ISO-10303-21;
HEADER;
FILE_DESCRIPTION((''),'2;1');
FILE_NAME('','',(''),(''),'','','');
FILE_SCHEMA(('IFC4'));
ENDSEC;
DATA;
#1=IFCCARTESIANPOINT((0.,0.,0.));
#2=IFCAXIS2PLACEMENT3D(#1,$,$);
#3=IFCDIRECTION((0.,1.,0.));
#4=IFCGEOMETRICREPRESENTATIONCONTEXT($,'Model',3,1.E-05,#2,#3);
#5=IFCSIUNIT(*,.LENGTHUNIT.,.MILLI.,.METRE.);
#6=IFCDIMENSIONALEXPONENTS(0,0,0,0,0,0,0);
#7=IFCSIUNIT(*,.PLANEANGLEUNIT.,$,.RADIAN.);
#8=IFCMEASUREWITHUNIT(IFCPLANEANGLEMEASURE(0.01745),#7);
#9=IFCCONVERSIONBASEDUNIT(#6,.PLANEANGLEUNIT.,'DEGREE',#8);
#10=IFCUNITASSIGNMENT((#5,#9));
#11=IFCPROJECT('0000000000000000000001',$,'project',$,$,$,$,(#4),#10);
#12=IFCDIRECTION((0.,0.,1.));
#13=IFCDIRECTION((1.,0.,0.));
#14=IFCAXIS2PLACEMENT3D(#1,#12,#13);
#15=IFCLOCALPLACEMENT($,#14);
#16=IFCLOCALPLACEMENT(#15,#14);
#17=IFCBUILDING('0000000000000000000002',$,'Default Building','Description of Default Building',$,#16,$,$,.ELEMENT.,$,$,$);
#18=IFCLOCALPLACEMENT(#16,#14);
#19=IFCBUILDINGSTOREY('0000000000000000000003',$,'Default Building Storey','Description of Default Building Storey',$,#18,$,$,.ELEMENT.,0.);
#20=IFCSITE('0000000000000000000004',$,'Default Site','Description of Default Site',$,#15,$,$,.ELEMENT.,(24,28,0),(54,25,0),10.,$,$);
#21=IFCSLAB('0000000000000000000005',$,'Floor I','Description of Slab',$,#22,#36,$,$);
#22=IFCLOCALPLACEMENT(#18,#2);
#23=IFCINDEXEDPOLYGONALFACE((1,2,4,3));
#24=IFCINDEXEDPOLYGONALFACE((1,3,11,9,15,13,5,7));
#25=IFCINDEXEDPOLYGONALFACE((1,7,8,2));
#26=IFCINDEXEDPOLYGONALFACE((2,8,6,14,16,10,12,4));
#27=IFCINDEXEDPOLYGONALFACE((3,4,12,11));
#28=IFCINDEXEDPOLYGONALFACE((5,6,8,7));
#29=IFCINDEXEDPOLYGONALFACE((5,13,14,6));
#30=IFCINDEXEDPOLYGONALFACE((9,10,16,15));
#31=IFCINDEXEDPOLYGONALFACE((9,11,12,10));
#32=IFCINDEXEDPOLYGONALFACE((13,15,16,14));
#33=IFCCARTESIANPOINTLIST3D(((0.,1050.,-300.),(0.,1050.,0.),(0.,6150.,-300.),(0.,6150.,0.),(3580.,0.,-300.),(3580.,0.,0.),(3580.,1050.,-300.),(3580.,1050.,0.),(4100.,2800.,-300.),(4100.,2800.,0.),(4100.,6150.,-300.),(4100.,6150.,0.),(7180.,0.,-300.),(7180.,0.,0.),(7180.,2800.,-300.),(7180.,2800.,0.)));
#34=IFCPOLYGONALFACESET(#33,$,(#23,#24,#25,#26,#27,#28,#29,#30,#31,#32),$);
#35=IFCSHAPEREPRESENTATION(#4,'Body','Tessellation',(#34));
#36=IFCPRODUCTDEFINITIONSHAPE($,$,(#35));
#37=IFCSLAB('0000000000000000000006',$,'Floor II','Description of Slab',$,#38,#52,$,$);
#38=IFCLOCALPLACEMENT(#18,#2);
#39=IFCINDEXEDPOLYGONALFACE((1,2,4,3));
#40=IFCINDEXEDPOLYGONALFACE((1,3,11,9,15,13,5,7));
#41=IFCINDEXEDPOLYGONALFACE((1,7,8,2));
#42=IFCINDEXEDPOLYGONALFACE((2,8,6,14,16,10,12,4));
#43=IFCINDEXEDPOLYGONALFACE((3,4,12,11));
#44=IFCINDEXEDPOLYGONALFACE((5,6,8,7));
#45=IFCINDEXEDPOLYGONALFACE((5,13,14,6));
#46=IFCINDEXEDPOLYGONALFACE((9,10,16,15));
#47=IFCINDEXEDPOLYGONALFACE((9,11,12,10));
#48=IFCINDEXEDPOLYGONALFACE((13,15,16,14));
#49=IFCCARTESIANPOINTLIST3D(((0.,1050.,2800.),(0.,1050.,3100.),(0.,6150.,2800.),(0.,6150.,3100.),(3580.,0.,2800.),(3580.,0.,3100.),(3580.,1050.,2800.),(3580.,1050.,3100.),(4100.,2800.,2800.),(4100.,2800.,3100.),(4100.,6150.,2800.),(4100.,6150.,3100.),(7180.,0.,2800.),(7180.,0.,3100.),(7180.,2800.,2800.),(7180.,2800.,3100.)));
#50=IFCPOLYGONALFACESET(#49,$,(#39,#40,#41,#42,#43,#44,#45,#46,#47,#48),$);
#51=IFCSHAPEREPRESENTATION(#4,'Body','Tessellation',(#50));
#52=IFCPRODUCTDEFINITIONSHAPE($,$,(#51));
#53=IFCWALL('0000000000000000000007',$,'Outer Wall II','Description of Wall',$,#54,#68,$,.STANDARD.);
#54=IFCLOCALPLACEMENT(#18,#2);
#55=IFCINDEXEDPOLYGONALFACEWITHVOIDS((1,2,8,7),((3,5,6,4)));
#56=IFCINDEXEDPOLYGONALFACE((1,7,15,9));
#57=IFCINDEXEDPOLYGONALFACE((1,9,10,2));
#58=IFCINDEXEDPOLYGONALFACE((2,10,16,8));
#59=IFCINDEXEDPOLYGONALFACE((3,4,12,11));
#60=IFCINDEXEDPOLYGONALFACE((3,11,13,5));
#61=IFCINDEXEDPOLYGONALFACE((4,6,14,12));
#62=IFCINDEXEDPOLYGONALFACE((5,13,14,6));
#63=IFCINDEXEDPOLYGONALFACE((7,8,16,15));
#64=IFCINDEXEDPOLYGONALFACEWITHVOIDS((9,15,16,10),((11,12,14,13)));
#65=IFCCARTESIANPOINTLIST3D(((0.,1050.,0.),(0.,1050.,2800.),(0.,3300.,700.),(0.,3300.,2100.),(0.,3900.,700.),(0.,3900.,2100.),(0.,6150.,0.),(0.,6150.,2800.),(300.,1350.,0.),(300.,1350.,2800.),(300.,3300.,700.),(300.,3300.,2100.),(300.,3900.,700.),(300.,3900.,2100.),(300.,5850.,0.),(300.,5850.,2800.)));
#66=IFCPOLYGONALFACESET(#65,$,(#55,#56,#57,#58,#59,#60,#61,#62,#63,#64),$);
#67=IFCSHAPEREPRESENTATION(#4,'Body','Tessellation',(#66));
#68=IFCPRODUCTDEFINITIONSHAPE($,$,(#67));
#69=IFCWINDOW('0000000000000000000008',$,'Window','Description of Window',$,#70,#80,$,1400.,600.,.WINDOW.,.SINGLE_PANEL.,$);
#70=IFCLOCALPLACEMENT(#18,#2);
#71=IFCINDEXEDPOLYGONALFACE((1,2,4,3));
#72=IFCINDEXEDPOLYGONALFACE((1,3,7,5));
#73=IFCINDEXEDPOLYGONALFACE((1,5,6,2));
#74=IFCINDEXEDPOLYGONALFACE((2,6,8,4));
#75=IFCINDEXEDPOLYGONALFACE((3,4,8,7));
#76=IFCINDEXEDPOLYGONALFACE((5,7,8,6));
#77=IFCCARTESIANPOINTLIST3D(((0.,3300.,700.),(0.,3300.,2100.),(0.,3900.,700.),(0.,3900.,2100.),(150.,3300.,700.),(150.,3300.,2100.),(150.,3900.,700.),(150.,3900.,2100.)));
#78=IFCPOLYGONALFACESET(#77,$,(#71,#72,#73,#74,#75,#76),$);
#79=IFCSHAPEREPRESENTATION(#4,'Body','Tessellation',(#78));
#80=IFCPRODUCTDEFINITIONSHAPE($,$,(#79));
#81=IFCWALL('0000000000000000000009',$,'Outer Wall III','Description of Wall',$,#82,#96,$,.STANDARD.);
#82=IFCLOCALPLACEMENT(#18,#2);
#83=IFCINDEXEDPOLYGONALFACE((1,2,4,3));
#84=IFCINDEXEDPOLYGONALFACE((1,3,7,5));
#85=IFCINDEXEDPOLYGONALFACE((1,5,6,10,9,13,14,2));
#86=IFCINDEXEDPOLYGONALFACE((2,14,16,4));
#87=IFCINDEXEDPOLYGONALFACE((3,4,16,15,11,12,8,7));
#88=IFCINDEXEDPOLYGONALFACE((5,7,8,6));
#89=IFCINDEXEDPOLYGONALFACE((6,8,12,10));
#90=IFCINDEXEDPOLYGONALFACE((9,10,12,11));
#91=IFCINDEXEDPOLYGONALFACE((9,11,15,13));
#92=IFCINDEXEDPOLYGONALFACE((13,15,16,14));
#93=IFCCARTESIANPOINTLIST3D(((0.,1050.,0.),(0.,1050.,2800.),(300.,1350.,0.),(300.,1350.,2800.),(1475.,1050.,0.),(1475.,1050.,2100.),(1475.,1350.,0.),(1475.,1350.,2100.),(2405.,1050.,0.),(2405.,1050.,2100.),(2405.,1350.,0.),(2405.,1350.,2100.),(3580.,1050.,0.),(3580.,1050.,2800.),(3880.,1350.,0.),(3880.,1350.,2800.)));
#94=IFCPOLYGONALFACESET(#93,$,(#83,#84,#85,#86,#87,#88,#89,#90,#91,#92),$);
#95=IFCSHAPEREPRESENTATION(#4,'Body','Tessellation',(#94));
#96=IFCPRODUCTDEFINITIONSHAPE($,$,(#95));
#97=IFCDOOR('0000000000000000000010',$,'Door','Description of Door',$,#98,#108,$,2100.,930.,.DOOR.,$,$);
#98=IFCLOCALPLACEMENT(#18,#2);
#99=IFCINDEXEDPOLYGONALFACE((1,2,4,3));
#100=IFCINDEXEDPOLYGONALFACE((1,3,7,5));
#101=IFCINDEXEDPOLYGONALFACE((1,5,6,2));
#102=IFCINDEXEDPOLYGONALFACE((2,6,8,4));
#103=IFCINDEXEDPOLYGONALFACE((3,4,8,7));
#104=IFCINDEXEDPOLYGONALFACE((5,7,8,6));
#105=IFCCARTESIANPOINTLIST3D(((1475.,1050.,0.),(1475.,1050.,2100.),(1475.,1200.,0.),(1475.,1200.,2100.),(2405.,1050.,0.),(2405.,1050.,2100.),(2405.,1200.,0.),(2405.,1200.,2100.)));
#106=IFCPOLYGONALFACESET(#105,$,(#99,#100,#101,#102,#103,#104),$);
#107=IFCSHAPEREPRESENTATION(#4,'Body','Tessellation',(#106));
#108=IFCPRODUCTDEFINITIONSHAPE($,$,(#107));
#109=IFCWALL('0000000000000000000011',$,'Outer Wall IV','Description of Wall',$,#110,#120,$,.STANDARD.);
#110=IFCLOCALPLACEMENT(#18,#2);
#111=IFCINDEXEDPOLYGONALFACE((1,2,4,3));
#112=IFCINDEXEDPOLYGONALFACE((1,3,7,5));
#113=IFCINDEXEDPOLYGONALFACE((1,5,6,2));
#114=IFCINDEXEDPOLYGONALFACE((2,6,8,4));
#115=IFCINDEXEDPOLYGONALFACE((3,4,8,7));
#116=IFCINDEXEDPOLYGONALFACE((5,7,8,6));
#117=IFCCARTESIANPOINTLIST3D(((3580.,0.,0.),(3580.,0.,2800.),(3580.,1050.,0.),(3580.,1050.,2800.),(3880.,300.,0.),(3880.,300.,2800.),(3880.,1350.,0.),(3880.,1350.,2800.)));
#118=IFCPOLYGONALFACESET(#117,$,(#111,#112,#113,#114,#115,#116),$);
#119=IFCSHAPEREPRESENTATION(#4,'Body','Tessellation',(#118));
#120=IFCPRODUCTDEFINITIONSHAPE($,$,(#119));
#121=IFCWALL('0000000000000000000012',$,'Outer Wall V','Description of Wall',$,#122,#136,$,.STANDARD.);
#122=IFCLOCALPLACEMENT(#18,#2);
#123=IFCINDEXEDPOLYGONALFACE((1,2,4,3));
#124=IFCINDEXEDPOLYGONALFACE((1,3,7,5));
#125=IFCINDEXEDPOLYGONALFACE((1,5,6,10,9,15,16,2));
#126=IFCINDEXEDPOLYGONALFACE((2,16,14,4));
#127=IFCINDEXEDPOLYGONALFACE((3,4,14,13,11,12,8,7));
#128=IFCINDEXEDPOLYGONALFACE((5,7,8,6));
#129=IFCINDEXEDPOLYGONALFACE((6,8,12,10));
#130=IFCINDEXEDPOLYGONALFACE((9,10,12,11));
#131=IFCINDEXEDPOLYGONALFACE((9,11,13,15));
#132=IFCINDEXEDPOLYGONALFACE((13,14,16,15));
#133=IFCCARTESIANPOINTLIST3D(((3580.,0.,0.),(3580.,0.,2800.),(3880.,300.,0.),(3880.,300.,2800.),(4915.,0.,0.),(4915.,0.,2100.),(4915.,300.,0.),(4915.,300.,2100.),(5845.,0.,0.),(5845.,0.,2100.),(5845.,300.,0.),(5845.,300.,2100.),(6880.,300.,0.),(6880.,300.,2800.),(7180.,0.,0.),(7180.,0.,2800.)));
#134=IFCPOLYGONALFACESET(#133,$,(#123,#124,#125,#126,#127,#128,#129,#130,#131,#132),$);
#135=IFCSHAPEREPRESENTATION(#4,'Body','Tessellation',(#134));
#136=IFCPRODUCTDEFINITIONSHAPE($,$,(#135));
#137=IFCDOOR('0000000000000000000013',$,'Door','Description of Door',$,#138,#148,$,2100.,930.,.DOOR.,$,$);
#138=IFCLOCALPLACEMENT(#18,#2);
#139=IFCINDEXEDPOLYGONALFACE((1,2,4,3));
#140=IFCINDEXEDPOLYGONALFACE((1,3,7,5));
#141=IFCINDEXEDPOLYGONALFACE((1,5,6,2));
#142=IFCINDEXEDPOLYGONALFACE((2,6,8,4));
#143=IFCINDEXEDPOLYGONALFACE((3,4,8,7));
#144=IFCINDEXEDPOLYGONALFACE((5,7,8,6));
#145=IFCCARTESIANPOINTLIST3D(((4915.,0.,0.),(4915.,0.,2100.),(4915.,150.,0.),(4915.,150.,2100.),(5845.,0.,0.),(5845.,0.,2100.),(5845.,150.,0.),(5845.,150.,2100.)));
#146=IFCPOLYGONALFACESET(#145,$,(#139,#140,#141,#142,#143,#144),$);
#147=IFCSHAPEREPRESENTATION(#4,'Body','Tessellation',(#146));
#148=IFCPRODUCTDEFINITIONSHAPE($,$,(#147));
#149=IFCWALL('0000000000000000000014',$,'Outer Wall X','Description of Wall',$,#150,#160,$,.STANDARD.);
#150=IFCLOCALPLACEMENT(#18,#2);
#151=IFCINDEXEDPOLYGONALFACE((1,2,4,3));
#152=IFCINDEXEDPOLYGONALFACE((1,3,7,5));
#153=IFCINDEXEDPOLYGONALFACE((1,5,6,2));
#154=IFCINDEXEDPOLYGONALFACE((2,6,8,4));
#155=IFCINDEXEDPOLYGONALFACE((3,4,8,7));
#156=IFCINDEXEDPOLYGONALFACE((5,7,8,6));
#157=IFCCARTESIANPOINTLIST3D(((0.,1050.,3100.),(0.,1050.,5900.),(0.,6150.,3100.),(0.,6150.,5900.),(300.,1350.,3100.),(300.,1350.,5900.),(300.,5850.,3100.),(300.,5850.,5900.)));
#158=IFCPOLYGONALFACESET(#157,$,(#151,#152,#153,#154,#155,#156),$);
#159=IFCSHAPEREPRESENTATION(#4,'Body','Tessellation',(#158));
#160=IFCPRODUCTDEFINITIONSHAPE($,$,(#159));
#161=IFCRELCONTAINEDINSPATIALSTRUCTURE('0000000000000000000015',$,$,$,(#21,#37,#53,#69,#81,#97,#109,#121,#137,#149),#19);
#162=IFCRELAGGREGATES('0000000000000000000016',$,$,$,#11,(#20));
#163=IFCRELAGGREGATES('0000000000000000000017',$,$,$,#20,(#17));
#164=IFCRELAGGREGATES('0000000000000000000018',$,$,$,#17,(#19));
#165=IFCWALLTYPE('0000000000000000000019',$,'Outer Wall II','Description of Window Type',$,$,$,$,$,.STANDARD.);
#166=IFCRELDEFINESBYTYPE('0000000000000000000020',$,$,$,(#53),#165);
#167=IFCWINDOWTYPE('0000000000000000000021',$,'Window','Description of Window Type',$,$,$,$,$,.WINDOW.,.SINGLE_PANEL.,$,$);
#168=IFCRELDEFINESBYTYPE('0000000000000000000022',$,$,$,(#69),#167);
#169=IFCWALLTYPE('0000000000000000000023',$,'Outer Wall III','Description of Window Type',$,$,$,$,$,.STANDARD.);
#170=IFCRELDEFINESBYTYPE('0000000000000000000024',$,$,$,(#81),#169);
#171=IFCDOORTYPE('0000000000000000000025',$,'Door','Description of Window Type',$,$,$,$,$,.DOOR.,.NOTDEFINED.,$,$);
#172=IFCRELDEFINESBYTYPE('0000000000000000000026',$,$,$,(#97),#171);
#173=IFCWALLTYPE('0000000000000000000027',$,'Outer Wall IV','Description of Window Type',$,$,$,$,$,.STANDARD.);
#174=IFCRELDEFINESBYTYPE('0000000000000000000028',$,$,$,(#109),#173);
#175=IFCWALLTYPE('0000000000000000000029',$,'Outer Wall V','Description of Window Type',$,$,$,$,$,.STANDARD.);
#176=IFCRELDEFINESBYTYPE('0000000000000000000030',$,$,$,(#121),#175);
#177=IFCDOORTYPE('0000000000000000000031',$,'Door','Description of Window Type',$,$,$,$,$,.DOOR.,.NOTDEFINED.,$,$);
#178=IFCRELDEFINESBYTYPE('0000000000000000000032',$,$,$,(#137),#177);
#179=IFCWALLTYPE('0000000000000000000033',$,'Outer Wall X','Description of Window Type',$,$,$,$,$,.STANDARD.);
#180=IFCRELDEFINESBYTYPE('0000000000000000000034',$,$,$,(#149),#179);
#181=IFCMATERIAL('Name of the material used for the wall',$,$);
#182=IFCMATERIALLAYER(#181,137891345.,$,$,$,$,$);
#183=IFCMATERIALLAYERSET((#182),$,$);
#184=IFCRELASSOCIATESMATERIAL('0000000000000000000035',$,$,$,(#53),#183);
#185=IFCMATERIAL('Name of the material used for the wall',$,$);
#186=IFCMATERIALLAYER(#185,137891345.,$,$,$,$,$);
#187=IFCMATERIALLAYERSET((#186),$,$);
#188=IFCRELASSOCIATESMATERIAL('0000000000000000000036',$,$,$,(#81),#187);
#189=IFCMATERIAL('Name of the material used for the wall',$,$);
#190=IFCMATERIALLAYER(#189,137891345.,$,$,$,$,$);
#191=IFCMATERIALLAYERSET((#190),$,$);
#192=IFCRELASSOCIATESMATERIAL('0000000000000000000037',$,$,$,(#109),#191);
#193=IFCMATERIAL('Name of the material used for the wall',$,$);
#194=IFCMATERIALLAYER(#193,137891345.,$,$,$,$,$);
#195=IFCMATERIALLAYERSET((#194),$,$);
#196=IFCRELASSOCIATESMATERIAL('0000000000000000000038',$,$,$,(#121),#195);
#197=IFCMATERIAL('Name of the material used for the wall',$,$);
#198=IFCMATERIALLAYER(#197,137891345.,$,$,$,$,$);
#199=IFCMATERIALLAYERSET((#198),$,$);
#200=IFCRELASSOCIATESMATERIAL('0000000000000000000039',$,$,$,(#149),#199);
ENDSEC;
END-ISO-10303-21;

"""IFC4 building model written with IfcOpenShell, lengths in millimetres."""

from ifc_helpers import new_model, entity, si_unit, converted_unit, direction, frame, origin, origin_with_axes, place, context, project, spatial, polyline, outline, extrude, material, layer, layer_set, layer_usage, type_object, element, fill, save


model = new_model("IFC4")

# Units and contexts
model_context = context("Model", 3, precision=1e-05, world=origin(), true_north=direction((0.0, 1.0, 0.0)))
ifc_project = project(units=[si_unit("LENGTHUNIT", "METRE", prefix="MILLI"), converted_unit("PLANEANGLEUNIT", "DEGREE", entity("IfcPlaneAngleMeasure", 0.01745), si_unit("PLANEANGLEUNIT", "RADIAN"), dimensions=[0, 0, 0, 0, 0, 0, 0])], contexts=[model_context])

# Site, building, storey
site_placement = place(None, origin_with_axes())
site = spatial("IfcSite", under=ifc_project, at=site_placement, Name="Default Site", Description="Description of Default Site", CompositionType="ELEMENT", RefLatitude=(24, 28, 0), RefLongitude=(54, 25, 0), RefElevation=10.0)
building_placement = place(site_placement, origin_with_axes())
building = spatial("IfcBuilding", under=site, at=building_placement, Name="Default Building", Description="Description of Default Building", CompositionType="ELEMENT")
storey_placement = place(building_placement, origin_with_axes())
storey = spatial("IfcBuildingStorey", under=building, at=storey_placement, Name="Default Building Storey", Description="Description of Default Building Storey", CompositionType="ELEMENT", Elevation=0.0)

# Slabs
for number, where, z_axis, x_axis, name in (
    (1, (0.0, 0.0, -300.0), (0.0, 0.0, 1.0), (1.0, 0.0, 0.0), "Floor I"),
    (2, (0.0, 0.0, 2800.0), (0.0, 0.0, 1.0), (1.0, 0.0, 0.0), "Floor II"),
):
    element("IfcSlab", number, at=place(storey_placement, frame(where, z_axis=z_axis, x_axis=x_axis)), inside=storey, Name=name, Description="Description of Slab", context=model_context, shape_type="SweptSolid", body=[
        extrude(outline(polyline([(0.0, 1050.0), (0.0, 6150.0), (4100.0, 6150.0), (4100.0, 2800.0), (7180.0, 2800.0), (7180.0, 0.0), (3580.0, 0.0), (3580.0, 1050.0), (0.0, 1050.0)])), origin_with_axes(), (0.0, 0.0, 1.0), 300.0),
    ])

# Wall, opening, window
ifc_material_1 = material(Name="Name of the material used for the wall")
ifc_layer_1 = layer(ifc_material_1, 137891345.0)
ifc_layer_set_1 = layer_set([ifc_layer_1])
ifc_layer_usage_1 = layer_usage(ifc_layer_set_1, "AXIS2", "POSITIVE", -68945672.5)
wall_type_1 = type_object("IfcWallType", Name="Outer Wall II", Description="Description of Window Type", PredefinedType="STANDARD")
wall_1_placement = place(storey_placement, frame((150.0, 6000.0, 0.0), z_axis=(0.0, 0.0, 1.0), x_axis=(0.0, -1.0, 0.0)))
wall_1 = element("IfcWall", 3, at=wall_1_placement, inside=storey, type_object=wall_type_1, material=ifc_layer_usage_1, Name="Outer Wall II", Description="Description of Wall", PredefinedType="STANDARD", context=model_context, shape_type="SweptSolid", body=[
    extrude(outline(polyline([(-150.0, -150.0), (150.0, 150.0), (4650.0, 150.0), (4950.0, -150.0), (-150.0, -150.0)])), origin_with_axes(), (0.0, 0.0, 1.0), 2800.0),
])
opening_1_placement = place(wall_1_placement, frame((2100.0, -150.0, 700.0), z_axis=(0.0, 0.0, 1.0), x_axis=(1.0, 0.0, 0.0)))
opening_1 = element("IfcOpeningElement", 4, at=opening_1_placement, cuts=wall_1, context=model_context, shape_type="SweptSolid", body=[
    extrude(outline(polyline([(0.0, 0.0), (0.0, 300.0), (600.0, 300.0), (600.0, 0.0), (0.0, 0.0)])), origin_with_axes(), (0.0, 0.0, 1.0), 1400.0),
])
window_type_1 = type_object("IfcWindowType", Name="Window", Description="Description of Window Type", PartitioningType="SINGLE_PANEL", PredefinedType="WINDOW")
window_1_placement = place(opening_1_placement, origin_with_axes())
window_1 = element("IfcWindow", 5, at=window_1_placement, inside=storey, type_object=window_type_1, Name="Window", Description="Description of Window", OverallHeight=1400.0, OverallWidth=600.0, PartitioningType="SINGLE_PANEL", PredefinedType="WINDOW", context=model_context, shape_type="SweptSolid", body=[
    extrude(outline(polyline([(0.0, 0.0), (0.0, 150.0), (600.0, 150.0), (600.0, 0.0), (0.0, 0.0)])), origin_with_axes(), (0.0, 0.0, 1.0), 1400.0),
])
fill(opening_1, window_1)

# Wall, opening, door
ifc_material_2 = material(Name="Name of the material used for the wall")
ifc_layer_2 = layer(ifc_material_2, 137891345.0)
ifc_layer_set_2 = layer_set([ifc_layer_2])
ifc_layer_usage_2 = layer_usage(ifc_layer_set_2, "AXIS2", "POSITIVE", -68945672.5)
wall_type_2 = type_object("IfcWallType", Name="Outer Wall III", Description="Description of Window Type", PredefinedType="STANDARD")
wall_2_placement = place(storey_placement, frame((150.0, 1200.0, 0.0), z_axis=(0.0, 0.0, 1.0), x_axis=(1.0, 0.0, 0.0)))
wall_2 = element("IfcWall", 6, at=wall_2_placement, inside=storey, type_object=wall_type_2, material=ifc_layer_usage_2, Name="Outer Wall III", Description="Description of Wall", PredefinedType="STANDARD", context=model_context, shape_type="SweptSolid", body=[
    extrude(outline(polyline([(-150.0, -150.0), (150.0, 150.0), (3730.0, 150.0), (3430.0, -150.0), (-150.0, -150.0)])), origin_with_axes(), (0.0, 0.0, 1.0), 2800.0),
])
opening_2_placement = place(wall_2_placement, frame((1325.0, -150.0, 0.0), z_axis=(0.0, 0.0, 1.0), x_axis=(1.0, 0.0, 0.0)))
opening_2 = element("IfcOpeningElement", 7, at=opening_2_placement, cuts=wall_2, context=model_context, shape_type="SweptSolid", body=[
    extrude(outline(polyline([(0.0, 0.0), (0.0, 300.0), (930.0, 300.0), (930.0, 0.0), (0.0, 0.0)])), origin_with_axes(), (0.0, 0.0, 1.0), 2100.0),
])
door_type_1 = type_object("IfcDoorType", Name="Door", Description="Description of Window Type", PredefinedType="DOOR")
door_1_placement = place(opening_2_placement, origin_with_axes())
door_1 = element("IfcDoor", 8, at=door_1_placement, inside=storey, type_object=door_type_1, Name="Door", Description="Description of Door", OverallHeight=2100.0, OverallWidth=930.0, PredefinedType="DOOR", context=model_context, shape_type="SweptSolid", body=[
    extrude(outline(polyline([(0.0, 0.0), (0.0, 150.0), (930.0, 150.0), (930.0, 0.0), (0.0, 0.0)])), origin_with_axes(), (0.0, 0.0, 1.0), 2100.0),
])
fill(opening_2, door_1)

# Wall
ifc_material_3 = material(Name="Name of the material used for the wall")
ifc_layer_3 = layer(ifc_material_3, 137891345.0)
ifc_layer_set_3 = layer_set([ifc_layer_3])
ifc_layer_usage_3 = layer_usage(ifc_layer_set_3, "AXIS2", "POSITIVE", -68945672.5)
wall_type_3 = type_object("IfcWallType", Name="Outer Wall IV", Description="Description of Window Type", PredefinedType="STANDARD")
wall_3_placement = place(storey_placement, frame((3730.0, 1200.0, 0.0), z_axis=(0.0, 0.0, 1.0), x_axis=(0.0, -1.0, 0.0)))
element("IfcWall", 9, at=wall_3_placement, inside=storey, type_object=wall_type_3, material=ifc_layer_usage_3, Name="Outer Wall IV", Description="Description of Wall", PredefinedType="STANDARD", context=model_context, shape_type="SweptSolid", body=[
    extrude(outline(polyline([(150.0, -150.0), (-150.0, 150.0), (900.0, 150.0), (1200.0, -150.0), (150.0, -150.0)])), origin_with_axes(), (0.0, 0.0, 1.0), 2800.0),
])

# Wall, opening, door
ifc_material_4 = material(Name="Name of the material used for the wall")
ifc_layer_4 = layer(ifc_material_4, 137891345.0)
ifc_layer_set_4 = layer_set([ifc_layer_4])
ifc_layer_usage_4 = layer_usage(ifc_layer_set_4, "AXIS2", "POSITIVE", -68945672.5)
wall_type_4 = type_object("IfcWallType", Name="Outer Wall V", Description="Description of Window Type", PredefinedType="STANDARD")
wall_4_placement = place(storey_placement, frame((3730.0, 150.0, 0.0), z_axis=(0.0, 0.0, 1.0), x_axis=(1.0, 0.0, 0.0)))
wall_4 = element("IfcWall", 10, at=wall_4_placement, inside=storey, type_object=wall_type_4, material=ifc_layer_usage_4, Name="Outer Wall V", Description="Description of Wall", PredefinedType="STANDARD", context=model_context, shape_type="SweptSolid", body=[
    extrude(outline(polyline([(-150.0, -150.0), (150.0, 150.0), (3150.0, 150.0), (3450.0, -150.0), (-150.0, -150.0)])), origin_with_axes(), (0.0, 0.0, 1.0), 2800.0),
])
opening_3_placement = place(wall_4_placement, frame((1185.0, -150.0, 0.0), z_axis=(0.0, 0.0, 1.0), x_axis=(1.0, 0.0, 0.0)))
opening_3 = element("IfcOpeningElement", 11, at=opening_3_placement, cuts=wall_4, context=model_context, shape_type="SweptSolid", body=[
    extrude(outline(polyline([(0.0, 0.0), (0.0, 300.0), (930.0, 300.0), (930.0, 0.0), (0.0, 0.0)])), origin_with_axes(), (0.0, 0.0, 1.0), 2100.0),
])
door_type_2 = type_object("IfcDoorType", Name="Door", Description="Description of Window Type", PredefinedType="DOOR")
door_2_placement = place(opening_3_placement, origin_with_axes())
door_2 = element("IfcDoor", 12, at=door_2_placement, inside=storey, type_object=door_type_2, Name="Door", Description="Description of Door", OverallHeight=2100.0, OverallWidth=930.0, PredefinedType="DOOR", context=model_context, shape_type="SweptSolid", body=[
    extrude(outline(polyline([(0.0, 0.0), (0.0, 150.0), (930.0, 150.0), (930.0, 0.0), (0.0, 0.0)])), origin_with_axes(), (0.0, 0.0, 1.0), 2100.0),
])
fill(opening_3, door_2)

# Wall
ifc_material_5 = material(Name="Name of the material used for the wall")
ifc_layer_5 = layer(ifc_material_5, 137891345.0)
ifc_layer_set_5 = layer_set([ifc_layer_5])
ifc_layer_usage_5 = layer_usage(ifc_layer_set_5, "AXIS2", "POSITIVE", -68945672.5)
wall_type_5 = type_object("IfcWallType", Name="Outer Wall X", Description="Description of Window Type", PredefinedType="STANDARD")
wall_5_placement = place(storey_placement, frame((150.0, 6000.0, 3100.0), z_axis=(0.0, 0.0, 1.0), x_axis=(0.0, -1.0, 0.0)))
element("IfcWall", 13, at=wall_5_placement, inside=storey, type_object=wall_type_5, material=ifc_layer_usage_5, Name="Outer Wall X", Description="Description of Wall", PredefinedType="STANDARD", context=model_context, shape_type="SweptSolid", body=[
    extrude(outline(polyline([(-150.0, -150.0), (150.0, 150.0), (4650.0, 150.0), (4950.0, -150.0), (-150.0, -150.0)])), origin_with_axes(), (0.0, 0.0, 1.0), 2800.0),
])

save(model, "model.ifc")
